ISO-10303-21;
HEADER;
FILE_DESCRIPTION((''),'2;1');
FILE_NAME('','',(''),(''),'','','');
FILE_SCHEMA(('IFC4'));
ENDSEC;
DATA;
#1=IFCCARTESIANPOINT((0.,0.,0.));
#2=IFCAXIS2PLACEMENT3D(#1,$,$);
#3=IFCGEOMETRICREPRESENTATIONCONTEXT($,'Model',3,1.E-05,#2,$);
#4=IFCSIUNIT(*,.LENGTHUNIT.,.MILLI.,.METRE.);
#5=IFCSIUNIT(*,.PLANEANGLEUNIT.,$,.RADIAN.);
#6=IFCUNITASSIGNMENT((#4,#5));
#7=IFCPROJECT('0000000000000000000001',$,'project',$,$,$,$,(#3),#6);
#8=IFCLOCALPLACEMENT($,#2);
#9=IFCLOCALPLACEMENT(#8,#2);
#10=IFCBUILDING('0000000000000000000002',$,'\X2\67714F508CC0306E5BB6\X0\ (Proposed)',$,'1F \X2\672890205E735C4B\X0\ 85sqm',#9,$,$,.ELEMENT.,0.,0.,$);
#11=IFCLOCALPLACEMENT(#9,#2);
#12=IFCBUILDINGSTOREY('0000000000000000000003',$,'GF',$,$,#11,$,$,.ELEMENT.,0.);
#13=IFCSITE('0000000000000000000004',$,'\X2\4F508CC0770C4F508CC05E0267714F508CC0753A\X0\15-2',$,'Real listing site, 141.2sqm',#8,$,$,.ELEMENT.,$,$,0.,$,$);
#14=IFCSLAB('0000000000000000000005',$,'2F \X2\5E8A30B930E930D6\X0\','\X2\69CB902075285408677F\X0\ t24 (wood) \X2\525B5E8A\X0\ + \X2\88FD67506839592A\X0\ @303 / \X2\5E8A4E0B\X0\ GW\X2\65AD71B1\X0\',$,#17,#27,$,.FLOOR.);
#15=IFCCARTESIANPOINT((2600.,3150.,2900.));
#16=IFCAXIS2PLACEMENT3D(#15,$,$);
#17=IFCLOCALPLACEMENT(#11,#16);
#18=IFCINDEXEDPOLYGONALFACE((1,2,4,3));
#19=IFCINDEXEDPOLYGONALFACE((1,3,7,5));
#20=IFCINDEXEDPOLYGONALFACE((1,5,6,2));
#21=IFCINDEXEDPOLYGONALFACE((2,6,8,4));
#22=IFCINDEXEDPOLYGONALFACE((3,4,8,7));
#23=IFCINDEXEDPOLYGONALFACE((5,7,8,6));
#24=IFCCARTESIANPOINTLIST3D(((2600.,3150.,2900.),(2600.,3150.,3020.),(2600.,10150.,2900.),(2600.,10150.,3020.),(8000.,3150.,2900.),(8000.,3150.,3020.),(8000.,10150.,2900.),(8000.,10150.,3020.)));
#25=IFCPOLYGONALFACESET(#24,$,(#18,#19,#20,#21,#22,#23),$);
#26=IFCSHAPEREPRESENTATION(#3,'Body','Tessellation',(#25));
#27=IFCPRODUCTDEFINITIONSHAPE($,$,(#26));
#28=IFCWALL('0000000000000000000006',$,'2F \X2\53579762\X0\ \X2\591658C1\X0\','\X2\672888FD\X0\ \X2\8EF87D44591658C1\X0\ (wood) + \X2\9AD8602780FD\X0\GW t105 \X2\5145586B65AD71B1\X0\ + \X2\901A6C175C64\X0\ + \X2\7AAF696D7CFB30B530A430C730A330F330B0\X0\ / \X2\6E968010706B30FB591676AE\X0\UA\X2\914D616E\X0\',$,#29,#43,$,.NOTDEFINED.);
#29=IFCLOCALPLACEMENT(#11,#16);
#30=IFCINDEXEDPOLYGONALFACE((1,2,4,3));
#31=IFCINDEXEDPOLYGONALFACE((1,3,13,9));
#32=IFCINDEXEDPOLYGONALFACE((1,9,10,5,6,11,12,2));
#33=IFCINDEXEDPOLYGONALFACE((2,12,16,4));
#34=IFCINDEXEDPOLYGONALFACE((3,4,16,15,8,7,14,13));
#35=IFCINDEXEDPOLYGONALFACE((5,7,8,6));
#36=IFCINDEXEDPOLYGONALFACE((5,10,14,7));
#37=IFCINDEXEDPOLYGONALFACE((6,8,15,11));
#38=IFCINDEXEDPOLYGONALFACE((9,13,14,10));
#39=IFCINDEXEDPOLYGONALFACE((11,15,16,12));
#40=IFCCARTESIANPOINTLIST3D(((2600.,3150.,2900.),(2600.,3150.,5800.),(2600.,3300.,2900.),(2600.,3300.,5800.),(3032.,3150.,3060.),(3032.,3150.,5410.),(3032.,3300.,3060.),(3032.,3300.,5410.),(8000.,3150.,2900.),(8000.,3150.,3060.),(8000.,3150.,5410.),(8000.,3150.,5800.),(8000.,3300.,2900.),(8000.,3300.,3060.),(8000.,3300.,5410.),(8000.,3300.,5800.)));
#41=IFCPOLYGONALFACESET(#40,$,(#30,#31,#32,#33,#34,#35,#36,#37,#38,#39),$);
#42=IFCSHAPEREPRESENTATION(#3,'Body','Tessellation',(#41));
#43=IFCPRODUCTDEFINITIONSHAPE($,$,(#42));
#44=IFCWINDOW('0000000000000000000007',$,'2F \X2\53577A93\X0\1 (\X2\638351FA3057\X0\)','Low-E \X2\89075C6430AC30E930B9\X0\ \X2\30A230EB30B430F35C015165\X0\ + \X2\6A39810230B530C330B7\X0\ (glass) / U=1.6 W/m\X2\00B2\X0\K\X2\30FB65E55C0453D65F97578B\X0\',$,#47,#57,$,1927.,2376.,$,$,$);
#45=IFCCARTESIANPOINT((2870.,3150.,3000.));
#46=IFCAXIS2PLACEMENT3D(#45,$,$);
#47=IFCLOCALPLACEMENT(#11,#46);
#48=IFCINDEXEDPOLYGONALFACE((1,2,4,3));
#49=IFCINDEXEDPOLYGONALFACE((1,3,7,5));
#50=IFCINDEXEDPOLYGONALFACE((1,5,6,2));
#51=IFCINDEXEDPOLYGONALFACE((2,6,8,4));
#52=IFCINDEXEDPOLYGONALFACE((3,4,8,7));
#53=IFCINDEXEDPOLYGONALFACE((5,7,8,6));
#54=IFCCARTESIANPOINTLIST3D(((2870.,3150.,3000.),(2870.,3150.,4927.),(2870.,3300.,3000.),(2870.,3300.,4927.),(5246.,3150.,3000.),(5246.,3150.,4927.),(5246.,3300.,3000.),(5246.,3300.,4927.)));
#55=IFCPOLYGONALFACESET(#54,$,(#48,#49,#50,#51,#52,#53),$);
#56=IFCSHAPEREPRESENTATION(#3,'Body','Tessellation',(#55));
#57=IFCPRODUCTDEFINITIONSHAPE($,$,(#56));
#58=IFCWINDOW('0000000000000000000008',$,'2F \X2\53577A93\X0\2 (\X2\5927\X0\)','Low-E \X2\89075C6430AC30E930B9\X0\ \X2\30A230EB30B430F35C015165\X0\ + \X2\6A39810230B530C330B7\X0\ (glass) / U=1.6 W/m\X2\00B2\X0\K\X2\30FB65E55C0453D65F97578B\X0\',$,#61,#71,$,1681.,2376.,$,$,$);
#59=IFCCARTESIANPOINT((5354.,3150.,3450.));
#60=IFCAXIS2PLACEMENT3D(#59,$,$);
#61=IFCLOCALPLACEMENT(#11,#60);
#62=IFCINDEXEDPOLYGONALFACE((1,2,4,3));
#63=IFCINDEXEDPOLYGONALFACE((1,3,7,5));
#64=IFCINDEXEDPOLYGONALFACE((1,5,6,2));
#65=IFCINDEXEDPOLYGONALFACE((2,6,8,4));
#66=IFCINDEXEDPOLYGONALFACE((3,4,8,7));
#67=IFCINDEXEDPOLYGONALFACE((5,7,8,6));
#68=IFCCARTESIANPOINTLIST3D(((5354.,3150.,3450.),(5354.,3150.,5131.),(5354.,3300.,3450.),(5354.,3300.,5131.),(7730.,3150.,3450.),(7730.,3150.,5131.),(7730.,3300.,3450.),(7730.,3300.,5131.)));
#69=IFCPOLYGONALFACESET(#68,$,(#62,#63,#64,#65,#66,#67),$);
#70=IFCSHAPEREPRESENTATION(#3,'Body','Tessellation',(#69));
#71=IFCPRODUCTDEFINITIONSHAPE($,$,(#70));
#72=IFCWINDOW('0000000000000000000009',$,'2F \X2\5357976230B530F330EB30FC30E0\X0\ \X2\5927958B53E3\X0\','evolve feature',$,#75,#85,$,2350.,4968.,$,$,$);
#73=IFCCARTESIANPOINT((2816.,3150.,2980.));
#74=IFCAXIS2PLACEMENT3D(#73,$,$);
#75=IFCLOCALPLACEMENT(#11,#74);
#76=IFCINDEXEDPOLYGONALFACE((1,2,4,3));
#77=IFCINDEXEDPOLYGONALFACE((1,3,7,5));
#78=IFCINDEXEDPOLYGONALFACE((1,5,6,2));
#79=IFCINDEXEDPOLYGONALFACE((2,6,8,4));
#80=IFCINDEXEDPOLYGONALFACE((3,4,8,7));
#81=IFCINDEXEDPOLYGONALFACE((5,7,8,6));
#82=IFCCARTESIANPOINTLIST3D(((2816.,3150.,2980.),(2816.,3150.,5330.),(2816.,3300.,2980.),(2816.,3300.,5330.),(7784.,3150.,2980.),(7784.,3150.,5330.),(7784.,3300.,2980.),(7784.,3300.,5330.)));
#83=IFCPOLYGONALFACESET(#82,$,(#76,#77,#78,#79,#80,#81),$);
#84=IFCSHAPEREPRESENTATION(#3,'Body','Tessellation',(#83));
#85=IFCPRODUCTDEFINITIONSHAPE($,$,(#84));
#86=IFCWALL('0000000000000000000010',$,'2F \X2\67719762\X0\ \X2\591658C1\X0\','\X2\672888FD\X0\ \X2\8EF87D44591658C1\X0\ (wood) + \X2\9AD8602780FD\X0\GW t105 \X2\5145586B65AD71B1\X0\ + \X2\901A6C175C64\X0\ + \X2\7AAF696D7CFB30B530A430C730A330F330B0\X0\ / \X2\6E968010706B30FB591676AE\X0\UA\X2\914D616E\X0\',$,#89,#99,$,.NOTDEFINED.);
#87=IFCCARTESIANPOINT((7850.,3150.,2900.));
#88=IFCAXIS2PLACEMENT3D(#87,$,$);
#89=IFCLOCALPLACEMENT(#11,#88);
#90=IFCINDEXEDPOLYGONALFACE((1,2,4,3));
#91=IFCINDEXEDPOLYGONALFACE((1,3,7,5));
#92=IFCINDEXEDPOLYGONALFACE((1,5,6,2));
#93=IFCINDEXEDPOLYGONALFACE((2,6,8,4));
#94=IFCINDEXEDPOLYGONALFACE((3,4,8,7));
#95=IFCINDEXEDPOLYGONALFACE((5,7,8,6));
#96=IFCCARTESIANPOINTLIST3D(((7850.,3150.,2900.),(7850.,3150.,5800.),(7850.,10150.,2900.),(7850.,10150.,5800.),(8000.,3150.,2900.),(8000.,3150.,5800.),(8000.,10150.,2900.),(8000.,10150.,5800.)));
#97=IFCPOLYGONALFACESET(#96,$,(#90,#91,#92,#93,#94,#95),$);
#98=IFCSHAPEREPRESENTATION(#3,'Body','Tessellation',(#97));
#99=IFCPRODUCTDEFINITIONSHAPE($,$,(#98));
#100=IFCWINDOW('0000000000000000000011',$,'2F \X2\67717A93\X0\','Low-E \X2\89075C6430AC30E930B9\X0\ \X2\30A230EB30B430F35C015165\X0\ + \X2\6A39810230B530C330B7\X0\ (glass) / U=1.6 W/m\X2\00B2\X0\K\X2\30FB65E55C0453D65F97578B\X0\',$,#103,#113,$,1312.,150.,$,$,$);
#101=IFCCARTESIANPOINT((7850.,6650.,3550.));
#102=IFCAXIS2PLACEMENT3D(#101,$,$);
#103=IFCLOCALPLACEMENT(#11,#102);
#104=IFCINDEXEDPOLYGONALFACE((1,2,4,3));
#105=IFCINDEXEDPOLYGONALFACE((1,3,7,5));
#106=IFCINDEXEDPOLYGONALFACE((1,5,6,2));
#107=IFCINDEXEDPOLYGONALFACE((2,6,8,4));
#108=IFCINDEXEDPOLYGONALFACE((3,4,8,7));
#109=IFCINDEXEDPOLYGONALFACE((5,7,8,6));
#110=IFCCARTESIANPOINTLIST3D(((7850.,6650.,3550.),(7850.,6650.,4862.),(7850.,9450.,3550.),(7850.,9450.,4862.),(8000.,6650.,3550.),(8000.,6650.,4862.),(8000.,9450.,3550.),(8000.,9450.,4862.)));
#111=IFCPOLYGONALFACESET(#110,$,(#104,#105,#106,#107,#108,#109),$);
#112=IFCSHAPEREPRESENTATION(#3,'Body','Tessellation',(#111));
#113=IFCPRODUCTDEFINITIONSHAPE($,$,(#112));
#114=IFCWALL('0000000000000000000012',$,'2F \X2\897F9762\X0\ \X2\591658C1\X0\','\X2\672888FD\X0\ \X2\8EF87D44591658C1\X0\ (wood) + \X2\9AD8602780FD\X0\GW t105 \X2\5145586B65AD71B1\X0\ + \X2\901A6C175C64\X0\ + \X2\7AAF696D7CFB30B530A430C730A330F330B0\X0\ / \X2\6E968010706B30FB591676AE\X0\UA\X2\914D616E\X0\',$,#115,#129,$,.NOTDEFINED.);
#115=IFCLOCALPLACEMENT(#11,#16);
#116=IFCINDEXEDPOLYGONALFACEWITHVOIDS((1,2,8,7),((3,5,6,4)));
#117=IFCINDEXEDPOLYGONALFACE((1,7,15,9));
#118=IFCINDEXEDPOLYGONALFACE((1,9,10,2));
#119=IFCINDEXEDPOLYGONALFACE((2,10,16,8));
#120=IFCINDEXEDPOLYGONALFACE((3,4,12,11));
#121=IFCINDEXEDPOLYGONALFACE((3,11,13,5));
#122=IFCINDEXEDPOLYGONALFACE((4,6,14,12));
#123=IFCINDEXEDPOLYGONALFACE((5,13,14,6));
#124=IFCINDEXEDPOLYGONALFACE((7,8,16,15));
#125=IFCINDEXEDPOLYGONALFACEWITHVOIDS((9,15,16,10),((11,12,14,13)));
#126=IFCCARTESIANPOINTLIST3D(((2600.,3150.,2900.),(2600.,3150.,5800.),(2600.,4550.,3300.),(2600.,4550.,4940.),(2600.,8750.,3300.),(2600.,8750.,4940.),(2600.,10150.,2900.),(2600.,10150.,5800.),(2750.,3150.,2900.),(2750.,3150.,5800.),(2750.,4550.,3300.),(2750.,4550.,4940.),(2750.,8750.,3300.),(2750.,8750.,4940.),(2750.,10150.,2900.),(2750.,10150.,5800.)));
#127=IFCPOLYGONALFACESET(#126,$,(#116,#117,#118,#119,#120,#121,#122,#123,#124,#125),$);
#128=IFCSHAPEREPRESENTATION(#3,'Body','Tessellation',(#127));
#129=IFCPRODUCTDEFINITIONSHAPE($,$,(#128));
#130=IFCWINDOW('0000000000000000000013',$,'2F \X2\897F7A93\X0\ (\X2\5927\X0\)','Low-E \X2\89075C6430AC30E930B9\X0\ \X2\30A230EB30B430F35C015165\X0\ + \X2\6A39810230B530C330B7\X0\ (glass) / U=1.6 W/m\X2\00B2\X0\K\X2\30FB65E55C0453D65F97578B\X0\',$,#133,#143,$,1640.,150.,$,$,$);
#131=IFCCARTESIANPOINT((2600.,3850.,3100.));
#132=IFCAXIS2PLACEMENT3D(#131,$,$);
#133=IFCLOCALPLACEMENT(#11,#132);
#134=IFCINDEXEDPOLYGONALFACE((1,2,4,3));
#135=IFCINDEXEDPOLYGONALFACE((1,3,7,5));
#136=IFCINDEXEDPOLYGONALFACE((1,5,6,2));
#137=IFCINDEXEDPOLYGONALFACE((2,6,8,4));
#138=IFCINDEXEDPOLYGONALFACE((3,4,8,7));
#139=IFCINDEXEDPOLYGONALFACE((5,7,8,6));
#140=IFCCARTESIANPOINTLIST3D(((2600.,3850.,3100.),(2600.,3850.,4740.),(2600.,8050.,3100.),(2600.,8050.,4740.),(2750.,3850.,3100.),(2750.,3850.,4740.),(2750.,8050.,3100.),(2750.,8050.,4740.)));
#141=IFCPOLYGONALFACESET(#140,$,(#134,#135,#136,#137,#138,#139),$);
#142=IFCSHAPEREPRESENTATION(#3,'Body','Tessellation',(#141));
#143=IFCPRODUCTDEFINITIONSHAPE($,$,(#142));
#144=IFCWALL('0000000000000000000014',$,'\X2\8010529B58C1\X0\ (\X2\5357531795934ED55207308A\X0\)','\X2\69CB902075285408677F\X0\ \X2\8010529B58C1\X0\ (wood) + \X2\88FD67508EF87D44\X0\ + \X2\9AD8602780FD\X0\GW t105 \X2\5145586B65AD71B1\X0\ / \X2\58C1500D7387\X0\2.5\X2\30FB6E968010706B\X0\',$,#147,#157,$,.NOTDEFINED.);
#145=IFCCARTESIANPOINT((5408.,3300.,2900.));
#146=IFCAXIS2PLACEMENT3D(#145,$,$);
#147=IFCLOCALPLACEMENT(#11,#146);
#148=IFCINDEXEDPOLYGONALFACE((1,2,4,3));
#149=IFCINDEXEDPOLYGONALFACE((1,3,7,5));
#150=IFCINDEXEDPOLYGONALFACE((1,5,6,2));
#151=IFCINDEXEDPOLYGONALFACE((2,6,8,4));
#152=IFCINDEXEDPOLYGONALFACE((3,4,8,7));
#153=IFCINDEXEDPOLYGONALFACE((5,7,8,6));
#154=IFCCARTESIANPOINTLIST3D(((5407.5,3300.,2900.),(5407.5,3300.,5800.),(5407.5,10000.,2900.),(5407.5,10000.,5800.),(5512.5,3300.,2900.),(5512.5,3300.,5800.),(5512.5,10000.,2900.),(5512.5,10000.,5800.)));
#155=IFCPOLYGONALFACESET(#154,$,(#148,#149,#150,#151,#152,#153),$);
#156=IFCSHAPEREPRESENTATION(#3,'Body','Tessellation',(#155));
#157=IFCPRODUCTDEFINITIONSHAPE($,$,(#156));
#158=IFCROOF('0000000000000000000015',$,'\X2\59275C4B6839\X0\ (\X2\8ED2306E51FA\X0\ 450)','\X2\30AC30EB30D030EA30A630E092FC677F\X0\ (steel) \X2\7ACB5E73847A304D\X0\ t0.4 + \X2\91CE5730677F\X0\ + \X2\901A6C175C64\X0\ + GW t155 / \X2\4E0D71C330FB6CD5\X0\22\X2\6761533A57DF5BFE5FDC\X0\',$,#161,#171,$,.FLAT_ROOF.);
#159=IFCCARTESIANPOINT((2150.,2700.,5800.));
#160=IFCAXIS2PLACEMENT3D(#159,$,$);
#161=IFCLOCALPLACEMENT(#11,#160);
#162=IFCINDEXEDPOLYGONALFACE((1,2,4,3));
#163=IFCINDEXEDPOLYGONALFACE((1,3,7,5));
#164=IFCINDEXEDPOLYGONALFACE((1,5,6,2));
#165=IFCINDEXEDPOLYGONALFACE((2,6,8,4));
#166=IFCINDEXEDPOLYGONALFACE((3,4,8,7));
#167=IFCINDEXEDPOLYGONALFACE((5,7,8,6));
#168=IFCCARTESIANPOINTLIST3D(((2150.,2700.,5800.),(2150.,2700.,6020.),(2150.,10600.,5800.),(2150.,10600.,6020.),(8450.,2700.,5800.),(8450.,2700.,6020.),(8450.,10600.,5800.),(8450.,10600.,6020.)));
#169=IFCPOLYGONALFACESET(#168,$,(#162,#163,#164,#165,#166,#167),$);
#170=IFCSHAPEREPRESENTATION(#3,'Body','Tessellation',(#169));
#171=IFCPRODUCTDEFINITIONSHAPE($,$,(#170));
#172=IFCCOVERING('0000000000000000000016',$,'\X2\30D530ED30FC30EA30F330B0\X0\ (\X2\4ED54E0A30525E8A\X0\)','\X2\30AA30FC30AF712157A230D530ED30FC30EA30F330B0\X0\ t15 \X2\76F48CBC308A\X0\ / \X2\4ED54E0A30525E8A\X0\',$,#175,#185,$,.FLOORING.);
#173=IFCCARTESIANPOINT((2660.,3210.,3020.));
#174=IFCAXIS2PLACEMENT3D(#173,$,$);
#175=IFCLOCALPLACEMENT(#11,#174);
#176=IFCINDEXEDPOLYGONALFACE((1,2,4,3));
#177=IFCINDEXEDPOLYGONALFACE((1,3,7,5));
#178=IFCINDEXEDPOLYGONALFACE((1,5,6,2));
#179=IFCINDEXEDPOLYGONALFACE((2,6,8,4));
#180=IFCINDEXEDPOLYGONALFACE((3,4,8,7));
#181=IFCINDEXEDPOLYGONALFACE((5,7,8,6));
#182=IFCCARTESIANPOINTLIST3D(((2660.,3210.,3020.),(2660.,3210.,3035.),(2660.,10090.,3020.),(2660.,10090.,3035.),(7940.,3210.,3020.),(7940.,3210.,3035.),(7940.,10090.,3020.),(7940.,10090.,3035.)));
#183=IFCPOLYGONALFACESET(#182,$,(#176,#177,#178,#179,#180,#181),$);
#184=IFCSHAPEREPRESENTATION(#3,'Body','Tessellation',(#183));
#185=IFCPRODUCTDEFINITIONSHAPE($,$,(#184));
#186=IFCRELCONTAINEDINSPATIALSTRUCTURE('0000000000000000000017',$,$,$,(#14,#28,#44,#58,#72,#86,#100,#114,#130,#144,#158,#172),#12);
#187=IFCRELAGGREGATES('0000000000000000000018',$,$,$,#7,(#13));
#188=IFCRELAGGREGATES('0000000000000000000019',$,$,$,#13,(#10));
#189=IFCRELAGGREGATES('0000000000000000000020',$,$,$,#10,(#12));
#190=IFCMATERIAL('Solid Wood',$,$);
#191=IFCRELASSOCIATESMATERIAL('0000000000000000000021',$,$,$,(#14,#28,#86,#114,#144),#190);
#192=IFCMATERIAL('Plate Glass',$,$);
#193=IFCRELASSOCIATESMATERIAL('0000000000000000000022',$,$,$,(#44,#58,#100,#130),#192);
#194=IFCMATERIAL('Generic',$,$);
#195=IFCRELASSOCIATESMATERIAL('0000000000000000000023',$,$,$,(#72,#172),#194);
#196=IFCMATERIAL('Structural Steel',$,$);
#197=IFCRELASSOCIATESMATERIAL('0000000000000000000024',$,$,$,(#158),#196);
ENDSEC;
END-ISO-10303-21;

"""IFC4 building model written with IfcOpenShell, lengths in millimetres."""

from ifc_helpers import new_model, si_unit, frame, frame_2d, origin, place, context, project, spatial, rectangle, extrude, material, element, fill, save


model = new_model("IFC4")

# Units and contexts
model_context = context("Model", 3, precision=1e-05, world=origin())
ifc_project = project(units=[si_unit("LENGTHUNIT", "METRE", prefix="MILLI"), si_unit("PLANEANGLEUNIT", "RADIAN")], contexts=[model_context])

# Site, building, storey
site_placement = place(None, origin())
site = spatial("IfcSite", under=ifc_project, at=site_placement, Name="佐賀県佐賀市東佐賀町15-2", ObjectType="Real listing site, 141.2sqm", CompositionType="ELEMENT", RefElevation=0.0)
building_placement = place(site_placement, origin())
building = spatial("IfcBuilding", under=site, at=building_placement, Name="東佐賀の家 (Proposed)", ObjectType="1F 木造平屋 85sqm", CompositionType="ELEMENT", ElevationOfRefHeight=0.0, ElevationOfTerrain=0.0)
storey_placement = place(building_placement, origin())
storey = spatial("IfcBuildingStorey", under=building, at=storey_placement, Name="GF", CompositionType="ELEMENT", Elevation=0.0)

# Slab
ifc_material_1 = material(Name="Solid Wood")
slab_placement = place(storey_placement, frame((2600.0, 3150.0, 2900.0)))
element("IfcSlab", 1, at=slab_placement, inside=storey, material=ifc_material_1, Name="2F 床スラブ", Description="構造用合板 t24 (wood) 剛床 + 製材根太 @303 / 床下 GW断熱", PredefinedType="FLOOR", context=model_context, shape_type="SweptSolid", body=[
    extrude(rectangle(XDim=5400.0, YDim=7000.0, at=frame_2d((2700.0, 3500.0))), frame((2600.0, 3150.0, 2900.0)), (0.0, 0.0, 1.0), 120.0),
])

# Wall, openings, windows
wall_1_placement = place(storey_placement, frame((2600.0, 3150.0, 2900.0)))
wall_1 = element("IfcWall", 2, at=wall_1_placement, inside=storey, material=ifc_material_1, Name="2F 南面 外壁", Description="木製 軸組外壁 (wood) + 高性能GW t105 充填断熱 + 通気層 + 窯業系サイディング / 準耐火・外皮UA配慮", PredefinedType="NOTDEFINED", context=model_context, shape_type="SweptSolid", body=[
    extrude(rectangle(XDim=5400.0, YDim=150.0, at=frame_2d((2700.0, 75.0))), frame((2600.0, 3150.0, 2900.0)), (0.0, 0.0, 1.0), 2900.0),
])
opening_1_placement = place(storey_placement, frame((2870.0, 3150.0, 3000.0)))
opening_1 = element("IfcOpeningElement", 3, at=opening_1_placement, cuts=wall_1, PredefinedType="NOTDEFINED", context=model_context, shape_type="SweptSolid", body=[
    extrude(rectangle(XDim=2376.0, YDim=150.0, at=frame_2d((1188.0, 75.0))), frame((2870.0, 3150.0, 3000.0)), (0.0, 0.0, 1.0), 1927.0),
])
opening_2_placement = place(storey_placement, frame((5354.0, 3150.0, 3450.0)))
opening_2 = element("IfcOpeningElement", 4, at=opening_2_placement, cuts=wall_1, PredefinedType="NOTDEFINED", context=model_context, shape_type="SweptSolid", body=[
    extrude(rectangle(XDim=2376.0, YDim=150.0, at=frame_2d((1188.0, 75.0))), frame((5354.0, 3150.0, 3450.0)), (0.0, 0.0, 1.0), 1681.0),
])
opening_3_placement = place(storey_placement, frame((2816.0, 3150.0, 2980.0)))
opening_3 = element("IfcOpeningElement", 5, at=opening_3_placement, cuts=wall_1, PredefinedType="NOTDEFINED", context=model_context, shape_type="SweptSolid", body=[
    extrude(rectangle(XDim=4968.0, YDim=150.0, at=frame_2d((2484.0, 75.0))), frame((2816.0, 3150.0, 2980.0)), (0.0, 0.0, 1.0), 2350.0),
])
ifc_material_2 = material(Name="Plate Glass")
window_1_placement = place(storey_placement, frame((2870.0, 3150.0, 3000.0)))
window_1 = element("IfcWindow", 6, at=window_1_placement, inside=storey, material=ifc_material_2, Name="2F 南窓1 (掃出し)", Description="Low-E 複層ガラス アルゴン封入 + 樹脂サッシ (glass) / U=1.6 W/m²K・日射取得型", OverallHeight=1927.0, OverallWidth=2376.0, context=model_context, shape_type="SweptSolid", body=[
    extrude(rectangle(XDim=2376.0, YDim=150.0, at=frame_2d((1188.0, 75.0))), frame((2870.0, 3150.0, 3000.0)), (0.0, 0.0, 1.0), 1927.0),
])
fill(opening_1, window_1)
window_2_placement = place(storey_placement, frame((5354.0, 3150.0, 3450.0)))
window_2 = element("IfcWindow", 7, at=window_2_placement, inside=storey, material=ifc_material_2, Name="2F 南窓2 (大)", Description="Low-E 複層ガラス アルゴン封入 + 樹脂サッシ (glass) / U=1.6 W/m²K・日射取得型", OverallHeight=1681.0, OverallWidth=2376.0, context=model_context, shape_type="SweptSolid", body=[
    extrude(rectangle(XDim=2376.0, YDim=150.0, at=frame_2d((1188.0, 75.0))), frame((5354.0, 3150.0, 3450.0)), (0.0, 0.0, 1.0), 1681.0),
])
fill(opening_2, window_2)
ifc_material_3 = material(Name="Generic")
window_3_placement = place(storey_placement, frame((2816.0, 3150.0, 2980.0)))
window_3 = element("IfcWindow", 8, at=window_3_placement, inside=storey, material=ifc_material_3, Name="2F 南面サンルーム 大開口", Description="evolve feature", OverallHeight=2350.0, OverallWidth=4968.0, context=model_context, shape_type="SweptSolid", body=[
    extrude(rectangle(XDim=4968.0, YDim=150.0, at=frame_2d((2484.0, 75.0))), frame((2816.0, 3150.0, 2980.0)), (0.0, 0.0, 1.0), 2350.0),
])
fill(opening_3, window_3)

# Walls, openings, windows
wall_2_placement = place(storey_placement, frame((7850.0, 3150.0, 2900.0)))
wall_2 = element("IfcWall", 9, at=wall_2_placement, inside=storey, material=ifc_material_1, Name="2F 東面 外壁", Description="木製 軸組外壁 (wood) + 高性能GW t105 充填断熱 + 通気層 + 窯業系サイディング / 準耐火・外皮UA配慮", PredefinedType="NOTDEFINED", context=model_context, shape_type="SweptSolid", body=[
    extrude(rectangle(XDim=150.0, YDim=7000.0, at=frame_2d((75.0, 3500.0))), frame((7850.0, 3150.0, 2900.0)), (0.0, 0.0, 1.0), 2900.0),
])
opening_4_placement = place(storey_placement, frame((7850.0, 6650.0, 3550.0)))
opening_4 = element("IfcOpeningElement", 10, at=opening_4_placement, cuts=wall_2, PredefinedType="NOTDEFINED", context=model_context, shape_type="SweptSolid", body=[
    extrude(rectangle(XDim=150.0, YDim=2800.0, at=frame_2d((75.0, 1400.0))), frame((7850.0, 6650.0, 3550.0)), (0.0, 0.0, 1.0), 1312.0),
])
window_4_placement = place(storey_placement, frame((7850.0, 6650.0, 3550.0)))
window_4 = element("IfcWindow", 11, at=window_4_placement, inside=storey, material=ifc_material_2, Name="2F 東窓", Description="Low-E 複層ガラス アルゴン封入 + 樹脂サッシ (glass) / U=1.6 W/m²K・日射取得型", OverallHeight=1312.0, OverallWidth=150.0, context=model_context, shape_type="SweptSolid", body=[
    extrude(rectangle(XDim=150.0, YDim=2800.0, at=frame_2d((75.0, 1400.0))), frame((7850.0, 6650.0, 3550.0)), (0.0, 0.0, 1.0), 1312.0),
])
fill(opening_4, window_4)
wall_3_placement = place(storey_placement, frame((2600.0, 3150.0, 2900.0)))
wall_3 = element("IfcWall", 12, at=wall_3_placement, inside=storey, material=ifc_material_1, Name="2F 西面 外壁", Description="木製 軸組外壁 (wood) + 高性能GW t105 充填断熱 + 通気層 + 窯業系サイディング / 準耐火・外皮UA配慮", PredefinedType="NOTDEFINED", context=model_context, shape_type="SweptSolid", body=[
    extrude(rectangle(XDim=150.0, YDim=7000.0, at=frame_2d((75.0, 3500.0))), frame((2600.0, 3150.0, 2900.0)), (0.0, 0.0, 1.0), 2900.0),
])
opening_5_placement = place(storey_placement, frame((2600.0, 3850.0, 3100.0)))
opening_5 = element("IfcOpeningElement", 13, at=opening_5_placement, cuts=wall_3, PredefinedType="NOTDEFINED", context=model_context, shape_type="SweptSolid", body=[
    extrude(rectangle(XDim=150.0, YDim=4200.0, at=frame_2d((75.0, 2100.0))), frame((2600.0, 3850.0, 3100.0)), (0.0, 0.0, 1.0), 1640.0),
])
window_5_placement = place(storey_placement, frame((2600.0, 3850.0, 3100.0)))
window_5 = element("IfcWindow", 14, at=window_5_placement, inside=storey, material=ifc_material_2, Name="2F 西窓 (大)", Description="Low-E 複層ガラス アルゴン封入 + 樹脂サッシ (glass) / U=1.6 W/m²K・日射取得型", OverallHeight=1640.0, OverallWidth=150.0, context=model_context, shape_type="SweptSolid", body=[
    extrude(rectangle(XDim=150.0, YDim=4200.0, at=frame_2d((75.0, 2100.0))), frame((2600.0, 3850.0, 3100.0)), (0.0, 0.0, 1.0), 1640.0),
])
fill(opening_5, window_5)

# Wall
wall_4_placement = place(storey_placement, frame((5408.0, 3300.0, 2900.0)))
element("IfcWall", 15, at=wall_4_placement, inside=storey, material=ifc_material_1, Name="耐力壁 (南北間仕切り)", Description="構造用合板 耐力壁 (wood) + 製材軸組 + 高性能GW t105 充填断熱 / 壁倍率2.5・準耐火", PredefinedType="NOTDEFINED", context=model_context, shape_type="SweptSolid", body=[
    extrude(rectangle(XDim=105.0, YDim=6700.0, at=frame_2d((52.0, 3350.0))), frame((5408.0, 3300.0, 2900.0)), (0.0, 0.0, 1.0), 2900.0),
])

# Roof
ifc_material_4 = material(Name="Structural Steel")
roof_placement = place(storey_placement, frame((2150.0, 2700.0, 5800.0)))
element("IfcRoof", 16, at=roof_placement, inside=storey, material=ifc_material_4, Name="大屋根 (軒の出 450)", Description="ガルバリウム鋼板 (steel) 立平葺き t0.4 + 野地板 + 通気層 + GW t155 / 不燃・法22条区域対応", PredefinedType="FLAT_ROOF", context=model_context, shape_type="SweptSolid", body=[
    extrude(rectangle(XDim=6300.0, YDim=7900.0, at=frame_2d((3150.0, 3950.0))), frame((2150.0, 2700.0, 5800.0)), (0.0, 0.0, 1.0), 220.0),
])

# Covering
covering_placement = place(storey_placement, frame((2660.0, 3210.0, 3020.0)))
element("IfcCovering", 17, at=covering_placement, inside=storey, material=ifc_material_3, Name="フローリング (仕上げ床)", Description="オーク無垢フローリング t15 直貼り / 仕上げ床", PredefinedType="FLOORING", context=model_context, shape_type="SweptSolid", body=[
    extrude(rectangle(XDim=5280.0, YDim=6880.0, at=frame_2d((2640.0, 3440.0))), frame((2660.0, 3210.0, 3020.0)), (0.0, 0.0, 1.0), 15.0),
])

save(model, "model.ifc")
